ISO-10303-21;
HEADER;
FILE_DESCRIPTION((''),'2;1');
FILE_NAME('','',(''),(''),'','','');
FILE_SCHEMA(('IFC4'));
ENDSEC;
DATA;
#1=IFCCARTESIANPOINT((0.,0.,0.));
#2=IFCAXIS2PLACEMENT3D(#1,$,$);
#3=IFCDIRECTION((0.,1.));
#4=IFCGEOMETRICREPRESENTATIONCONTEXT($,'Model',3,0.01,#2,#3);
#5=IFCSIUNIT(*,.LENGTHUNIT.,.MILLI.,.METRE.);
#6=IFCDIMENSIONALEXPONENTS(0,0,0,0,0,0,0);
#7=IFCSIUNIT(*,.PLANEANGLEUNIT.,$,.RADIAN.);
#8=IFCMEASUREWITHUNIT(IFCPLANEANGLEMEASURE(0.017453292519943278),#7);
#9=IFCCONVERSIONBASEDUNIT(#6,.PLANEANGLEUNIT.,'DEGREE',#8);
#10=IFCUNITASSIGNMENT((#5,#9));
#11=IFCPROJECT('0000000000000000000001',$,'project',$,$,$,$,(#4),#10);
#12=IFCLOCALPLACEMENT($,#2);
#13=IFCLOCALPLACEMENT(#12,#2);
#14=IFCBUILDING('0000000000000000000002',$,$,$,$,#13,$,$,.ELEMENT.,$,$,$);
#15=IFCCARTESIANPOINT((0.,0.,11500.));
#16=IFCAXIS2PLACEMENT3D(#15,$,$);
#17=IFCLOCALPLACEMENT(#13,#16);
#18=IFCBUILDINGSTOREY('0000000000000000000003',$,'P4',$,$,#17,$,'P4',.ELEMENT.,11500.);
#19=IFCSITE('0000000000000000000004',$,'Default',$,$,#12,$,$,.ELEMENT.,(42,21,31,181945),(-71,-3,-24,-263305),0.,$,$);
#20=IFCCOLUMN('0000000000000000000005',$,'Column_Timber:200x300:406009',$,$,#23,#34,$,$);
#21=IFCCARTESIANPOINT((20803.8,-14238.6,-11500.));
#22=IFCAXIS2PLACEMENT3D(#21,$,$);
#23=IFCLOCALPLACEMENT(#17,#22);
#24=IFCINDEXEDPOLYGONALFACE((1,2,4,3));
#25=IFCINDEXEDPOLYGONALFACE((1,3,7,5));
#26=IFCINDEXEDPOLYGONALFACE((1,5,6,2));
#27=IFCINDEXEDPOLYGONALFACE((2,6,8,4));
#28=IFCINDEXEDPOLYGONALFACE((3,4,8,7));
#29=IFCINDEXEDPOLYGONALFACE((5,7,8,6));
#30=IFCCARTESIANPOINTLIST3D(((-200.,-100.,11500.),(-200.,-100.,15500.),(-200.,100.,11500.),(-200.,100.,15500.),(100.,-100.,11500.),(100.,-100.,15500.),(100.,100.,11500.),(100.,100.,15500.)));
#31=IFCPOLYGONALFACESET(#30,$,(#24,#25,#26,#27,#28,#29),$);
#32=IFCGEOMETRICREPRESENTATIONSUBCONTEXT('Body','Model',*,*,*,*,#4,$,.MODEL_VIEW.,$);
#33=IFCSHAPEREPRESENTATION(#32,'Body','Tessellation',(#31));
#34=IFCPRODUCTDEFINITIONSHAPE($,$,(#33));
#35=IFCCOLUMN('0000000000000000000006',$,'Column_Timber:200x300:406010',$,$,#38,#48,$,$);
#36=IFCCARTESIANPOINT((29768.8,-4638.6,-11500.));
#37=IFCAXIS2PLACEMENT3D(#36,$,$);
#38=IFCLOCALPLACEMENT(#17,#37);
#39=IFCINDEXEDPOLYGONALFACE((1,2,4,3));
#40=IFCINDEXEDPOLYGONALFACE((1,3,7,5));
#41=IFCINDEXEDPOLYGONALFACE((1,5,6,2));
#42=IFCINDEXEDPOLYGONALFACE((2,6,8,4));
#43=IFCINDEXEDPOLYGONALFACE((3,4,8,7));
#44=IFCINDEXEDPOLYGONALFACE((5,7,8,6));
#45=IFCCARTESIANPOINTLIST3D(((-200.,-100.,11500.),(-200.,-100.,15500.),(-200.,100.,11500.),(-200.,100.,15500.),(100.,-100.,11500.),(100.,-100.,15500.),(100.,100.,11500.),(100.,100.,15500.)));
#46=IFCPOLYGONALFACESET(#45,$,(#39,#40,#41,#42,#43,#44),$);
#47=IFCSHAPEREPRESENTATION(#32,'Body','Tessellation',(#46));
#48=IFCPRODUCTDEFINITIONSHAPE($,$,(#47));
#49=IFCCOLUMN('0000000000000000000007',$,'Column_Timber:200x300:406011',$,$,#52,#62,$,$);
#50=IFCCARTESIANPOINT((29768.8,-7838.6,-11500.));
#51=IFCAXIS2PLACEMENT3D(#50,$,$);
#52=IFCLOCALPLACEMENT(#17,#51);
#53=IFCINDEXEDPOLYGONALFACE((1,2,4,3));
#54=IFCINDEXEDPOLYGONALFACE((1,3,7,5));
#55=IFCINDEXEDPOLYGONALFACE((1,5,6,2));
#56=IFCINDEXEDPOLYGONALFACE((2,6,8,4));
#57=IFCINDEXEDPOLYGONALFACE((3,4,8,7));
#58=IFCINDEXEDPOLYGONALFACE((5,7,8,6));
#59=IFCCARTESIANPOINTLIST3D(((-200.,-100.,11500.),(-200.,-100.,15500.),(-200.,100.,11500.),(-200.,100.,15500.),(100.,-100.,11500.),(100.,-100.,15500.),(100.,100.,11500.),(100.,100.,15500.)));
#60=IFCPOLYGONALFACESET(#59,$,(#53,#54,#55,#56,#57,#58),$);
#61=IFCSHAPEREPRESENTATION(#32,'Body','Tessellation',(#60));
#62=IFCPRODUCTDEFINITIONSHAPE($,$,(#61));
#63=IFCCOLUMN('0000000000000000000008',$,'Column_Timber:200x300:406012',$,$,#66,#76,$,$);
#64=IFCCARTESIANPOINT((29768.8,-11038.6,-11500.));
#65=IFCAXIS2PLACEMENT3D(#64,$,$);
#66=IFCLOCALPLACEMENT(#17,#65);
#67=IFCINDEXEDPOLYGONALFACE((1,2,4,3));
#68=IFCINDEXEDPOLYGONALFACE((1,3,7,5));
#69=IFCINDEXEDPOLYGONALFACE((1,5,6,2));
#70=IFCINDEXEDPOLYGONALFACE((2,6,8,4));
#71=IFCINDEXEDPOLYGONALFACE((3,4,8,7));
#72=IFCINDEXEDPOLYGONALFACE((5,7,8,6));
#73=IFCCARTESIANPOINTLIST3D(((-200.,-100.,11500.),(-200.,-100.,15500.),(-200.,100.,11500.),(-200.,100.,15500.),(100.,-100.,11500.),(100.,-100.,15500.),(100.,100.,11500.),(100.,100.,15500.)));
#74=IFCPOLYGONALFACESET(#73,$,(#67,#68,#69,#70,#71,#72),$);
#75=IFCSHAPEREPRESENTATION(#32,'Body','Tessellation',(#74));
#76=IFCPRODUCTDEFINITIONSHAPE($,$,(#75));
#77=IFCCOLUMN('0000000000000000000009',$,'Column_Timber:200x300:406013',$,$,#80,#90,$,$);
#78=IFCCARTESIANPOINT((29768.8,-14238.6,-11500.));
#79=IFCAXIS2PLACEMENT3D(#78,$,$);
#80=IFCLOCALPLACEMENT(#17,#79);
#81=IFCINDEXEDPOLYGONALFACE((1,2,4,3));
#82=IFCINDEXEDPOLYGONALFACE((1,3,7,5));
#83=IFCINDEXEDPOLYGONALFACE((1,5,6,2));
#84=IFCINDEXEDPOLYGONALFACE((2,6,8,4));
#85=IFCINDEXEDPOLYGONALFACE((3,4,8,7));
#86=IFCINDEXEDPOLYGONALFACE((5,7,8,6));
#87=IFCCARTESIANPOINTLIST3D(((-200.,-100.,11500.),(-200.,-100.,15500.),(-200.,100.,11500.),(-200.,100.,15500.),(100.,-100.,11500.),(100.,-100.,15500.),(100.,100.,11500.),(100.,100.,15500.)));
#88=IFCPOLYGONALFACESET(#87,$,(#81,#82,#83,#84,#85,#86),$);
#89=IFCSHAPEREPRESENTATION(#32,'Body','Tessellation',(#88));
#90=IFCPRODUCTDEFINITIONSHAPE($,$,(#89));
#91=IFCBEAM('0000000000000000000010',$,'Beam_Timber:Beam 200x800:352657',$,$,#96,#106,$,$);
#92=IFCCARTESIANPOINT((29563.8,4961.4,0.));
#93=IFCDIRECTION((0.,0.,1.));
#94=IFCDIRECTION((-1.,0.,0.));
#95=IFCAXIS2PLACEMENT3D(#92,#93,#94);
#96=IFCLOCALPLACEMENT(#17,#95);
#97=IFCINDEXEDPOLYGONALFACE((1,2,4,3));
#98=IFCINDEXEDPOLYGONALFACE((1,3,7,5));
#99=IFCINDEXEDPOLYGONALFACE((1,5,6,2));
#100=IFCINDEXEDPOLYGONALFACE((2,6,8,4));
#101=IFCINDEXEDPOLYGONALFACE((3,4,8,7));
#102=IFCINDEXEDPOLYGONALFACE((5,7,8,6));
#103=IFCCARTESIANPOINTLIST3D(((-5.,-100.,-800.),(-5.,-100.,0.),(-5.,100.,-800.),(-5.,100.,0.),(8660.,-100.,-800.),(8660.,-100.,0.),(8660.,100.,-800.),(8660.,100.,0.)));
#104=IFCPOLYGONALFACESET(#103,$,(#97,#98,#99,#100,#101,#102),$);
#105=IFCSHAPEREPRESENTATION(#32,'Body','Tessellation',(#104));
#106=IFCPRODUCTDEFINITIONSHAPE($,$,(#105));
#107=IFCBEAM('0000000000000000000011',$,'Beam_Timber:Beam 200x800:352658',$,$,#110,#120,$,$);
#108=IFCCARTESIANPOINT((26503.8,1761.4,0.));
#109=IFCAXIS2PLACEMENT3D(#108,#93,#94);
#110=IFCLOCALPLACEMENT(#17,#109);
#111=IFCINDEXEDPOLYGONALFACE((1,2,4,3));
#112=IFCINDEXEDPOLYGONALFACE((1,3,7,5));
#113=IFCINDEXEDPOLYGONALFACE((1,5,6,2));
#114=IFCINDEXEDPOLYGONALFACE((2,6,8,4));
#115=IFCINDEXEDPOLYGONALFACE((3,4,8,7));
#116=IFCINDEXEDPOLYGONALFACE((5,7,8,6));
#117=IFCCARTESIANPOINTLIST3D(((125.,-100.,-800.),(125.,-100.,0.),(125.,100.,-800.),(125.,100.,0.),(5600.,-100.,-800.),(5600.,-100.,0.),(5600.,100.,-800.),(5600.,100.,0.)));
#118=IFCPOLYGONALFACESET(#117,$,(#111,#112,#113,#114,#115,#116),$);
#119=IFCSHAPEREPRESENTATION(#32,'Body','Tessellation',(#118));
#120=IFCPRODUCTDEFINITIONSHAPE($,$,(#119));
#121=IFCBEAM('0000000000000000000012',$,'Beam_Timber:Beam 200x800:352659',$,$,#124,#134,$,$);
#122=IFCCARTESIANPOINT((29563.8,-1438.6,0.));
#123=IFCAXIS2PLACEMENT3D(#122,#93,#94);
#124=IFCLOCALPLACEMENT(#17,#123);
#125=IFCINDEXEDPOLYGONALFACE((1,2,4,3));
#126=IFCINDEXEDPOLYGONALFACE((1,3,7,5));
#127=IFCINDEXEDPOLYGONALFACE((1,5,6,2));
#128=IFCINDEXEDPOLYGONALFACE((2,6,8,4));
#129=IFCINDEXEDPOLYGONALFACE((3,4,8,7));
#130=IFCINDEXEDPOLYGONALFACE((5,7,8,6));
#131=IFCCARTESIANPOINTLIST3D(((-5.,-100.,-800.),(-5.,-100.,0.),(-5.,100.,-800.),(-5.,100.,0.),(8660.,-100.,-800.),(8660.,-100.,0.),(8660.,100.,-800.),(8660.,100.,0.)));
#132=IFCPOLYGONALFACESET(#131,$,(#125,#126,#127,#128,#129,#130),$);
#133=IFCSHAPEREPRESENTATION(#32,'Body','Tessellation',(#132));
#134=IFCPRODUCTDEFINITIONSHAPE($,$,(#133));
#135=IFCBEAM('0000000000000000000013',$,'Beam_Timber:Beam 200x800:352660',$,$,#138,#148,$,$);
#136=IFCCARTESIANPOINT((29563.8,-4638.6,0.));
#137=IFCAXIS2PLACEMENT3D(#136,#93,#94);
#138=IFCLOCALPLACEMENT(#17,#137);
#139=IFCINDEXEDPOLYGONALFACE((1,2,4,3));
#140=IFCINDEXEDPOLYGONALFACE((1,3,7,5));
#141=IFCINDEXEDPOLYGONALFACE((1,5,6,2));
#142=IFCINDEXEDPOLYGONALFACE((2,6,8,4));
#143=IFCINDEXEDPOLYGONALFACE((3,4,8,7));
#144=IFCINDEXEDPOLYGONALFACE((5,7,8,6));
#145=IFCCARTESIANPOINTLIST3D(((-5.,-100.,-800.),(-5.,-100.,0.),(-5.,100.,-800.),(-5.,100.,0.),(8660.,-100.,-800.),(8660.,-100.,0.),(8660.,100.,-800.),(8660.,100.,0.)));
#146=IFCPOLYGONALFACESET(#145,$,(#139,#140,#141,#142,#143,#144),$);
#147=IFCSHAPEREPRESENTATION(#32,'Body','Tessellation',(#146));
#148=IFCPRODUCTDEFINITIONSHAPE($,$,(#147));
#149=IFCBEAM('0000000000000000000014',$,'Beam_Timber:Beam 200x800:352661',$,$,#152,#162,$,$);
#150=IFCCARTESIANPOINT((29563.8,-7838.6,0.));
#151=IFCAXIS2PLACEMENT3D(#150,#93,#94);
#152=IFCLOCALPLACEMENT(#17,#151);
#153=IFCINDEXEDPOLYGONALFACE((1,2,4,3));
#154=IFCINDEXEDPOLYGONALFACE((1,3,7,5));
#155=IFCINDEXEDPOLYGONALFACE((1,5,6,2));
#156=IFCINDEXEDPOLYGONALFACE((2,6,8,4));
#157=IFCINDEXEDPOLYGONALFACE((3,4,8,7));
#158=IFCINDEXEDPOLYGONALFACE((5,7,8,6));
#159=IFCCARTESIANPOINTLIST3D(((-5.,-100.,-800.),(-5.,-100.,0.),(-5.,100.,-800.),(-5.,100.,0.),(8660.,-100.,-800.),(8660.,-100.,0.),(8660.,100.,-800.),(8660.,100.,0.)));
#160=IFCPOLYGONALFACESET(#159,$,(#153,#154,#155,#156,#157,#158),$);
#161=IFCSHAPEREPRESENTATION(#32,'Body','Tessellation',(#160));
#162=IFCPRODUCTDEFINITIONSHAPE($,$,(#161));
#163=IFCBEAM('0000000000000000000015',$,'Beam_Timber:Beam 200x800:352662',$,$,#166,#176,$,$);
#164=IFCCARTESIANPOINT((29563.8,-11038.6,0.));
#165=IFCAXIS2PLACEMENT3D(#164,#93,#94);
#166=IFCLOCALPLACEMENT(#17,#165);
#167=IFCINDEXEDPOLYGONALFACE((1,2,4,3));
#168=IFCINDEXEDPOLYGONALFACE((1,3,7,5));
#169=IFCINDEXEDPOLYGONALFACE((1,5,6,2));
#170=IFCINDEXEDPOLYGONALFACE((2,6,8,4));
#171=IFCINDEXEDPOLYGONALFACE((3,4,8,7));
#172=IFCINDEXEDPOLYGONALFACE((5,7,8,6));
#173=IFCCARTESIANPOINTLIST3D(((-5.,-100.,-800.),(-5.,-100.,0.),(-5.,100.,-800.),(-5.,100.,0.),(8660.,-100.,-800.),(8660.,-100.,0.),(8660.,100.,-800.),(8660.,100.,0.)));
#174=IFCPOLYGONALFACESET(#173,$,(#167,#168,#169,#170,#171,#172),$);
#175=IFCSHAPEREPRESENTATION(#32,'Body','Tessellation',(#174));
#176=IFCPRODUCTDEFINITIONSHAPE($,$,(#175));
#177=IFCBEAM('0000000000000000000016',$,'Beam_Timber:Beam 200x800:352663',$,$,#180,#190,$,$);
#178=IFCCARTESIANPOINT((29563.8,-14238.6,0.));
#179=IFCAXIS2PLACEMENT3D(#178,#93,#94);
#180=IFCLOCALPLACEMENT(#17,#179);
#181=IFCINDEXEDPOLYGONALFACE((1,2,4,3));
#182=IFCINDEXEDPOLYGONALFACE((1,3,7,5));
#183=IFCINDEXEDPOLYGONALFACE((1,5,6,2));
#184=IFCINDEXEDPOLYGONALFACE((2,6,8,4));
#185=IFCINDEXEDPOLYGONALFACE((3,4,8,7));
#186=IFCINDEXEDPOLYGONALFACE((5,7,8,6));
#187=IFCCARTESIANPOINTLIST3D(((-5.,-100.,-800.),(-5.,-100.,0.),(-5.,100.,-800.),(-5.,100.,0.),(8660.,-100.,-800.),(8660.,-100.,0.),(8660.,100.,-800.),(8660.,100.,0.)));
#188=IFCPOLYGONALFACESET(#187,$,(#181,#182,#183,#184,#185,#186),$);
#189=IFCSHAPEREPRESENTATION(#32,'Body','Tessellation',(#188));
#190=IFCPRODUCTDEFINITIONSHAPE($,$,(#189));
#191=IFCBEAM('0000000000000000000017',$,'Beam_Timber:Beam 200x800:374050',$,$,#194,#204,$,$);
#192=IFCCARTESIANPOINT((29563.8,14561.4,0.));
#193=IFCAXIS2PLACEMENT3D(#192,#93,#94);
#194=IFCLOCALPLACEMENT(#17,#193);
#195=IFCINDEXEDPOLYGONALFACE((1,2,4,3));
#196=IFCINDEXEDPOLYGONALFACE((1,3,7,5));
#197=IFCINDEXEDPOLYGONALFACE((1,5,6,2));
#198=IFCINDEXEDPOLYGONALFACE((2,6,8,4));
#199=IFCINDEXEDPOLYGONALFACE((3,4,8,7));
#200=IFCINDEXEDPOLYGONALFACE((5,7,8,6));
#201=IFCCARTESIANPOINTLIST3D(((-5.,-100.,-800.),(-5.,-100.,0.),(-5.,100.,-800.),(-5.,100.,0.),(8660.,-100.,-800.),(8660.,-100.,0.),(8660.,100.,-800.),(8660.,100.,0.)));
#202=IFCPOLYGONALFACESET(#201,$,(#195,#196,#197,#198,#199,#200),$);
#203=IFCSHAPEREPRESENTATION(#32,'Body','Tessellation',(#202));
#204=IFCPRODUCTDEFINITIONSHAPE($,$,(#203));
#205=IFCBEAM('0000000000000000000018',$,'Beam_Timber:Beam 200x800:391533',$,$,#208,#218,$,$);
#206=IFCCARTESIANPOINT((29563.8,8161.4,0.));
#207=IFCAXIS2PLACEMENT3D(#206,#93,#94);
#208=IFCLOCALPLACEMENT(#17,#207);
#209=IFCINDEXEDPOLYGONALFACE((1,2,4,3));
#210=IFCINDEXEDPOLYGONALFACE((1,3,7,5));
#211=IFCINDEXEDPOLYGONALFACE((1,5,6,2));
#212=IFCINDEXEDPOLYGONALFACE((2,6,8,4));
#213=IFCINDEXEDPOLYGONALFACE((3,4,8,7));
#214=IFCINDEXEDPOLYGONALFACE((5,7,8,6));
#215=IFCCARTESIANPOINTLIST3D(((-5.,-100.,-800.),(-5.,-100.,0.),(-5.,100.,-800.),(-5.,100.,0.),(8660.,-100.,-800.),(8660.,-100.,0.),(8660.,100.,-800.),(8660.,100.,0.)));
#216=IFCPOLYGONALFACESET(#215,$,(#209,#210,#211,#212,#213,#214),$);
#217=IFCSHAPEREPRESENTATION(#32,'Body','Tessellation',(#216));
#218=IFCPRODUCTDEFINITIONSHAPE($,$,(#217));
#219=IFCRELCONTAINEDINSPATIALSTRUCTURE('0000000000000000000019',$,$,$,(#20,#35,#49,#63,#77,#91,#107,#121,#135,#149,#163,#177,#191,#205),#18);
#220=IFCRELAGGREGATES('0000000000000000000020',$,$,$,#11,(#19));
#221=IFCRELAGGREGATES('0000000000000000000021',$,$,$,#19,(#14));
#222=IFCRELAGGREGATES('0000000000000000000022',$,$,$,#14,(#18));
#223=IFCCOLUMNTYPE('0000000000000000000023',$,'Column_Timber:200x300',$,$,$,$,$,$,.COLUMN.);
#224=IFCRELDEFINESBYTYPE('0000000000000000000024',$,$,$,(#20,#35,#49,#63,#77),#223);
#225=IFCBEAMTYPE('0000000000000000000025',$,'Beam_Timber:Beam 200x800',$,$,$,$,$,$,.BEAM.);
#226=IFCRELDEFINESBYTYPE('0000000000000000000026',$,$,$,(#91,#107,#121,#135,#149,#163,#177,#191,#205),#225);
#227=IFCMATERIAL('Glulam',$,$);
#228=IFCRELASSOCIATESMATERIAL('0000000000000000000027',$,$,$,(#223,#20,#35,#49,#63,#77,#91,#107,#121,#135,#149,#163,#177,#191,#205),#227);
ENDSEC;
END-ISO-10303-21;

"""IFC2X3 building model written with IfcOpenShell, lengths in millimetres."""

from ifc_helpers import new_model, entity, si_unit, converted_unit, direction, frame, frame_2d, origin, origin_2d_with_axis, place, context, subcontext, project, spatial, rectangle, extrude, source, transform, mapped, material, type_object, type_shapes, element, save


model = new_model("IFC2X3")

# Units and contexts
model_context = context("Model", 3, precision=0.01, world=origin(), true_north=direction((0.0, 1.0)))
body_context = subcontext(model_context, "Body", "Model", "MODEL_VIEW")
ifc_project = project(units=[si_unit("LENGTHUNIT", "METRE", prefix="MILLI"), converted_unit("PLANEANGLEUNIT", "DEGREE", entity("IfcPlaneAngleMeasure", 0.017453292519943278), si_unit("PLANEANGLEUNIT", "RADIAN"), dimensions=[0, 0, 0, 0, 0, 0, 0])], contexts=[model_context])

# Site, building, storey
site_placement = place(None, origin())
site = spatial("IfcSite", under=ifc_project, at=site_placement, Name="Default", CompositionType="ELEMENT", RefLatitude=(42, 21, 31, 181945), RefLongitude=(-71, -3, -24, -263305), RefElevation=0.0)
building_placement = place(site_placement, origin())
building = spatial("IfcBuilding", under=site, at=building_placement, CompositionType="ELEMENT")
storey_placement = place(building_placement, frame((0.0, 0.0, 11500.0)))
storey = spatial("IfcBuildingStorey", under=building, at=storey_placement, Name="P4", LongName="P4", CompositionType="ELEMENT", Elevation=11500.0)

# Columns
ifc_material = material(Name="Glulam")
column_type_1 = type_object("IfcColumnType", Name="Column_Timber:200x300", PredefinedType="COLUMN", material=ifc_material)
shared_shape_1 = source(origin(), body_context, "Body", "SweptSolid", [
    extrude(rectangle(XDim=300.0, YDim=200.0, at=origin_2d_with_axis()), frame((-50.0, 0.0, 11500.0), z_axis=(0.0, 0.0, 1.0), x_axis=(-1.0, 0.0, 0.0)), (0.0, 0.0, 1.0), 4000.0),
])
type_shapes(column_type_1, [shared_shape_1])
for number, where, name in (
    (1, (20803.8, -14238.6, -11500.0), "Column_Timber:200x300:406009"),
    (2, (29768.8, -4638.6, -11500.0), "Column_Timber:200x300:406010"),
    (3, (29768.8, -7838.6, -11500.0), "Column_Timber:200x300:406011"),
    (4, (29768.8, -11038.6, -11500.0), "Column_Timber:200x300:406012"),
    (5, (29768.8, -14238.6, -11500.0), "Column_Timber:200x300:406013"),
):
    element("IfcColumn", number, at=place(storey_placement, frame(where)), inside=storey, type_object=column_type_1, material=ifc_material, Name=name, context=body_context, shape_type="MappedRepresentation", body=[
        mapped(shared_shape_1, transform((0.0, 0.0, 0.0), scale=1.0)),
    ])

# Beams
beam_type_1 = type_object("IfcBeamType", Name="Beam_Timber:Beam 200x800", PredefinedType="BEAM")
beam_1_placement = place(storey_placement, frame((29563.8, 4961.4, 0.0), z_axis=(0.0, 0.0, 1.0), x_axis=(-1.0, 0.0, 0.0)))
element("IfcBeam", 6, at=beam_1_placement, inside=storey, type_object=beam_type_1, material=ifc_material, Name="Beam_Timber:Beam 200x800:352657", context=body_context, shape_type="SweptSolid", body=[
    extrude(rectangle(XDim=800.0, YDim=200.0, at=origin_2d_with_axis()), frame((-5.0, 0.0, -400.0), z_axis=(1.0, 0.0, 0.0), x_axis=(0.0, 0.0, -1.0)), (0.0, 0.0, 1.0), 8665.0),
])
beam_2_placement = place(storey_placement, frame((26503.8, 1761.4, 0.0), z_axis=(0.0, 0.0, 1.0), x_axis=(-1.0, 0.0, 0.0)))
element("IfcBeam", 7, at=beam_2_placement, inside=storey, type_object=beam_type_1, material=ifc_material, Name="Beam_Timber:Beam 200x800:352658", context=body_context, shape_type="SweptSolid", body=[
    extrude(rectangle(XDim=800.0, YDim=200.0, at=frame_2d((0.0, 0.0), x_axis=(1.0, 0.0))), frame((125.0, 0.0, -400.0), z_axis=(1.0, 0.0, 0.0), x_axis=(0.0, 0.0, -1.0)), (0.0, 0.0, 1.0), 5475.0),
])
beam_3_placement = place(storey_placement, frame((29563.8, -1438.6, 0.0), z_axis=(0.0, 0.0, 1.0), x_axis=(-1.0, 0.0, 0.0)))
element("IfcBeam", 8, at=beam_3_placement, inside=storey, type_object=beam_type_1, material=ifc_material, Name="Beam_Timber:Beam 200x800:352659", context=body_context, shape_type="SweptSolid", body=[
    extrude(rectangle(XDim=800.0, YDim=200.0, at=frame_2d((0.0, 0.0), x_axis=(1.0, 0.0))), frame((-5.0, 0.0, -400.0), z_axis=(1.0, 0.0, 0.0), x_axis=(0.0, 0.0, -1.0)), (0.0, 0.0, 1.0), 8665.0),
])
beam_4_placement = place(storey_placement, frame((29563.8, -4638.6, 0.0), z_axis=(0.0, 0.0, 1.0), x_axis=(-1.0, 0.0, 0.0)))
element("IfcBeam", 9, at=beam_4_placement, inside=storey, type_object=beam_type_1, material=ifc_material, Name="Beam_Timber:Beam 200x800:352660", context=body_context, shape_type="SweptSolid", body=[
    extrude(rectangle(XDim=800.0, YDim=200.0, at=frame_2d((0.0, 0.0), x_axis=(1.0, 0.0))), frame((-5.0, 0.0, -400.0), z_axis=(1.0, 0.0, 0.0), x_axis=(0.0, 0.0, -1.0)), (0.0, 0.0, 1.0), 8665.0),
])
beam_5_placement = place(storey_placement, frame((29563.8, -7838.6, 0.0), z_axis=(0.0, 0.0, 1.0), x_axis=(-1.0, 0.0, 0.0)))
element("IfcBeam", 10, at=beam_5_placement, inside=storey, type_object=beam_type_1, material=ifc_material, Name="Beam_Timber:Beam 200x800:352661", context=body_context, shape_type="SweptSolid", body=[
    extrude(rectangle(XDim=800.0, YDim=200.0, at=frame_2d((0.0, 0.0), x_axis=(1.0, 0.0))), frame((-5.0, 0.0, -400.0), z_axis=(1.0, 0.0, 0.0), x_axis=(0.0, 0.0, -1.0)), (0.0, 0.0, 1.0), 8665.0),
])
beam_6_placement = place(storey_placement, frame((29563.8, -11038.6, 0.0), z_axis=(0.0, 0.0, 1.0), x_axis=(-1.0, 0.0, 0.0)))
element("IfcBeam", 11, at=beam_6_placement, inside=storey, type_object=beam_type_1, material=ifc_material, Name="Beam_Timber:Beam 200x800:352662", context=body_context, shape_type="SweptSolid", body=[
    extrude(rectangle(XDim=800.0, YDim=200.0, at=frame_2d((0.0, 0.0), x_axis=(1.0, 0.0))), frame((-5.0, 0.0, -400.0), z_axis=(1.0, 0.0, 0.0), x_axis=(0.0, 0.0, -1.0)), (0.0, 0.0, 1.0), 8665.0),
])
beam_7_placement = place(storey_placement, frame((29563.8, -14238.6, 0.0), z_axis=(0.0, 0.0, 1.0), x_axis=(-1.0, 0.0, 0.0)))
element("IfcBeam", 12, at=beam_7_placement, inside=storey, type_object=beam_type_1, material=ifc_material, Name="Beam_Timber:Beam 200x800:352663", context=body_context, shape_type="SweptSolid", body=[
    extrude(rectangle(XDim=800.0, YDim=200.0, at=frame_2d((0.0, 0.0), x_axis=(1.0, 0.0))), frame((-5.0, 0.0, -400.0), z_axis=(1.0, 0.0, 0.0), x_axis=(0.0, 0.0, -1.0)), (0.0, 0.0, 1.0), 8665.0),
])
beam_8_placement = place(storey_placement, frame((29563.8, 14561.4, 0.0), z_axis=(0.0, 0.0, 1.0), x_axis=(-1.0, 0.0, 0.0)))
element("IfcBeam", 13, at=beam_8_placement, inside=storey, type_object=beam_type_1, material=ifc_material, Name="Beam_Timber:Beam 200x800:374050", context=body_context, shape_type="SweptSolid", body=[
    extrude(rectangle(XDim=800.0, YDim=200.0, at=frame_2d((0.0, 0.0), x_axis=(1.0, 0.0))), frame((-5.0, 0.0, -400.0), z_axis=(1.0, 0.0, 0.0), x_axis=(0.0, 0.0, -1.0)), (0.0, 0.0, 1.0), 8665.0),
])
beam_9_placement = place(storey_placement, frame((29563.8, 8161.4, 0.0), z_axis=(0.0, 0.0, 1.0), x_axis=(-1.0, 0.0, 0.0)))
element("IfcBeam", 14, at=beam_9_placement, inside=storey, type_object=beam_type_1, material=ifc_material, Name="Beam_Timber:Beam 200x800:391533", context=body_context, shape_type="SweptSolid", body=[
    extrude(rectangle(XDim=800.0, YDim=200.0, at=frame_2d((0.0, 0.0), x_axis=(1.0, 0.0))), frame((-5.0, 0.0, -400.0), z_axis=(1.0, 0.0, 0.0), x_axis=(0.0, 0.0, -1.0)), (0.0, 0.0, 1.0), 8665.0),
])

save(model, "model.ifc")
